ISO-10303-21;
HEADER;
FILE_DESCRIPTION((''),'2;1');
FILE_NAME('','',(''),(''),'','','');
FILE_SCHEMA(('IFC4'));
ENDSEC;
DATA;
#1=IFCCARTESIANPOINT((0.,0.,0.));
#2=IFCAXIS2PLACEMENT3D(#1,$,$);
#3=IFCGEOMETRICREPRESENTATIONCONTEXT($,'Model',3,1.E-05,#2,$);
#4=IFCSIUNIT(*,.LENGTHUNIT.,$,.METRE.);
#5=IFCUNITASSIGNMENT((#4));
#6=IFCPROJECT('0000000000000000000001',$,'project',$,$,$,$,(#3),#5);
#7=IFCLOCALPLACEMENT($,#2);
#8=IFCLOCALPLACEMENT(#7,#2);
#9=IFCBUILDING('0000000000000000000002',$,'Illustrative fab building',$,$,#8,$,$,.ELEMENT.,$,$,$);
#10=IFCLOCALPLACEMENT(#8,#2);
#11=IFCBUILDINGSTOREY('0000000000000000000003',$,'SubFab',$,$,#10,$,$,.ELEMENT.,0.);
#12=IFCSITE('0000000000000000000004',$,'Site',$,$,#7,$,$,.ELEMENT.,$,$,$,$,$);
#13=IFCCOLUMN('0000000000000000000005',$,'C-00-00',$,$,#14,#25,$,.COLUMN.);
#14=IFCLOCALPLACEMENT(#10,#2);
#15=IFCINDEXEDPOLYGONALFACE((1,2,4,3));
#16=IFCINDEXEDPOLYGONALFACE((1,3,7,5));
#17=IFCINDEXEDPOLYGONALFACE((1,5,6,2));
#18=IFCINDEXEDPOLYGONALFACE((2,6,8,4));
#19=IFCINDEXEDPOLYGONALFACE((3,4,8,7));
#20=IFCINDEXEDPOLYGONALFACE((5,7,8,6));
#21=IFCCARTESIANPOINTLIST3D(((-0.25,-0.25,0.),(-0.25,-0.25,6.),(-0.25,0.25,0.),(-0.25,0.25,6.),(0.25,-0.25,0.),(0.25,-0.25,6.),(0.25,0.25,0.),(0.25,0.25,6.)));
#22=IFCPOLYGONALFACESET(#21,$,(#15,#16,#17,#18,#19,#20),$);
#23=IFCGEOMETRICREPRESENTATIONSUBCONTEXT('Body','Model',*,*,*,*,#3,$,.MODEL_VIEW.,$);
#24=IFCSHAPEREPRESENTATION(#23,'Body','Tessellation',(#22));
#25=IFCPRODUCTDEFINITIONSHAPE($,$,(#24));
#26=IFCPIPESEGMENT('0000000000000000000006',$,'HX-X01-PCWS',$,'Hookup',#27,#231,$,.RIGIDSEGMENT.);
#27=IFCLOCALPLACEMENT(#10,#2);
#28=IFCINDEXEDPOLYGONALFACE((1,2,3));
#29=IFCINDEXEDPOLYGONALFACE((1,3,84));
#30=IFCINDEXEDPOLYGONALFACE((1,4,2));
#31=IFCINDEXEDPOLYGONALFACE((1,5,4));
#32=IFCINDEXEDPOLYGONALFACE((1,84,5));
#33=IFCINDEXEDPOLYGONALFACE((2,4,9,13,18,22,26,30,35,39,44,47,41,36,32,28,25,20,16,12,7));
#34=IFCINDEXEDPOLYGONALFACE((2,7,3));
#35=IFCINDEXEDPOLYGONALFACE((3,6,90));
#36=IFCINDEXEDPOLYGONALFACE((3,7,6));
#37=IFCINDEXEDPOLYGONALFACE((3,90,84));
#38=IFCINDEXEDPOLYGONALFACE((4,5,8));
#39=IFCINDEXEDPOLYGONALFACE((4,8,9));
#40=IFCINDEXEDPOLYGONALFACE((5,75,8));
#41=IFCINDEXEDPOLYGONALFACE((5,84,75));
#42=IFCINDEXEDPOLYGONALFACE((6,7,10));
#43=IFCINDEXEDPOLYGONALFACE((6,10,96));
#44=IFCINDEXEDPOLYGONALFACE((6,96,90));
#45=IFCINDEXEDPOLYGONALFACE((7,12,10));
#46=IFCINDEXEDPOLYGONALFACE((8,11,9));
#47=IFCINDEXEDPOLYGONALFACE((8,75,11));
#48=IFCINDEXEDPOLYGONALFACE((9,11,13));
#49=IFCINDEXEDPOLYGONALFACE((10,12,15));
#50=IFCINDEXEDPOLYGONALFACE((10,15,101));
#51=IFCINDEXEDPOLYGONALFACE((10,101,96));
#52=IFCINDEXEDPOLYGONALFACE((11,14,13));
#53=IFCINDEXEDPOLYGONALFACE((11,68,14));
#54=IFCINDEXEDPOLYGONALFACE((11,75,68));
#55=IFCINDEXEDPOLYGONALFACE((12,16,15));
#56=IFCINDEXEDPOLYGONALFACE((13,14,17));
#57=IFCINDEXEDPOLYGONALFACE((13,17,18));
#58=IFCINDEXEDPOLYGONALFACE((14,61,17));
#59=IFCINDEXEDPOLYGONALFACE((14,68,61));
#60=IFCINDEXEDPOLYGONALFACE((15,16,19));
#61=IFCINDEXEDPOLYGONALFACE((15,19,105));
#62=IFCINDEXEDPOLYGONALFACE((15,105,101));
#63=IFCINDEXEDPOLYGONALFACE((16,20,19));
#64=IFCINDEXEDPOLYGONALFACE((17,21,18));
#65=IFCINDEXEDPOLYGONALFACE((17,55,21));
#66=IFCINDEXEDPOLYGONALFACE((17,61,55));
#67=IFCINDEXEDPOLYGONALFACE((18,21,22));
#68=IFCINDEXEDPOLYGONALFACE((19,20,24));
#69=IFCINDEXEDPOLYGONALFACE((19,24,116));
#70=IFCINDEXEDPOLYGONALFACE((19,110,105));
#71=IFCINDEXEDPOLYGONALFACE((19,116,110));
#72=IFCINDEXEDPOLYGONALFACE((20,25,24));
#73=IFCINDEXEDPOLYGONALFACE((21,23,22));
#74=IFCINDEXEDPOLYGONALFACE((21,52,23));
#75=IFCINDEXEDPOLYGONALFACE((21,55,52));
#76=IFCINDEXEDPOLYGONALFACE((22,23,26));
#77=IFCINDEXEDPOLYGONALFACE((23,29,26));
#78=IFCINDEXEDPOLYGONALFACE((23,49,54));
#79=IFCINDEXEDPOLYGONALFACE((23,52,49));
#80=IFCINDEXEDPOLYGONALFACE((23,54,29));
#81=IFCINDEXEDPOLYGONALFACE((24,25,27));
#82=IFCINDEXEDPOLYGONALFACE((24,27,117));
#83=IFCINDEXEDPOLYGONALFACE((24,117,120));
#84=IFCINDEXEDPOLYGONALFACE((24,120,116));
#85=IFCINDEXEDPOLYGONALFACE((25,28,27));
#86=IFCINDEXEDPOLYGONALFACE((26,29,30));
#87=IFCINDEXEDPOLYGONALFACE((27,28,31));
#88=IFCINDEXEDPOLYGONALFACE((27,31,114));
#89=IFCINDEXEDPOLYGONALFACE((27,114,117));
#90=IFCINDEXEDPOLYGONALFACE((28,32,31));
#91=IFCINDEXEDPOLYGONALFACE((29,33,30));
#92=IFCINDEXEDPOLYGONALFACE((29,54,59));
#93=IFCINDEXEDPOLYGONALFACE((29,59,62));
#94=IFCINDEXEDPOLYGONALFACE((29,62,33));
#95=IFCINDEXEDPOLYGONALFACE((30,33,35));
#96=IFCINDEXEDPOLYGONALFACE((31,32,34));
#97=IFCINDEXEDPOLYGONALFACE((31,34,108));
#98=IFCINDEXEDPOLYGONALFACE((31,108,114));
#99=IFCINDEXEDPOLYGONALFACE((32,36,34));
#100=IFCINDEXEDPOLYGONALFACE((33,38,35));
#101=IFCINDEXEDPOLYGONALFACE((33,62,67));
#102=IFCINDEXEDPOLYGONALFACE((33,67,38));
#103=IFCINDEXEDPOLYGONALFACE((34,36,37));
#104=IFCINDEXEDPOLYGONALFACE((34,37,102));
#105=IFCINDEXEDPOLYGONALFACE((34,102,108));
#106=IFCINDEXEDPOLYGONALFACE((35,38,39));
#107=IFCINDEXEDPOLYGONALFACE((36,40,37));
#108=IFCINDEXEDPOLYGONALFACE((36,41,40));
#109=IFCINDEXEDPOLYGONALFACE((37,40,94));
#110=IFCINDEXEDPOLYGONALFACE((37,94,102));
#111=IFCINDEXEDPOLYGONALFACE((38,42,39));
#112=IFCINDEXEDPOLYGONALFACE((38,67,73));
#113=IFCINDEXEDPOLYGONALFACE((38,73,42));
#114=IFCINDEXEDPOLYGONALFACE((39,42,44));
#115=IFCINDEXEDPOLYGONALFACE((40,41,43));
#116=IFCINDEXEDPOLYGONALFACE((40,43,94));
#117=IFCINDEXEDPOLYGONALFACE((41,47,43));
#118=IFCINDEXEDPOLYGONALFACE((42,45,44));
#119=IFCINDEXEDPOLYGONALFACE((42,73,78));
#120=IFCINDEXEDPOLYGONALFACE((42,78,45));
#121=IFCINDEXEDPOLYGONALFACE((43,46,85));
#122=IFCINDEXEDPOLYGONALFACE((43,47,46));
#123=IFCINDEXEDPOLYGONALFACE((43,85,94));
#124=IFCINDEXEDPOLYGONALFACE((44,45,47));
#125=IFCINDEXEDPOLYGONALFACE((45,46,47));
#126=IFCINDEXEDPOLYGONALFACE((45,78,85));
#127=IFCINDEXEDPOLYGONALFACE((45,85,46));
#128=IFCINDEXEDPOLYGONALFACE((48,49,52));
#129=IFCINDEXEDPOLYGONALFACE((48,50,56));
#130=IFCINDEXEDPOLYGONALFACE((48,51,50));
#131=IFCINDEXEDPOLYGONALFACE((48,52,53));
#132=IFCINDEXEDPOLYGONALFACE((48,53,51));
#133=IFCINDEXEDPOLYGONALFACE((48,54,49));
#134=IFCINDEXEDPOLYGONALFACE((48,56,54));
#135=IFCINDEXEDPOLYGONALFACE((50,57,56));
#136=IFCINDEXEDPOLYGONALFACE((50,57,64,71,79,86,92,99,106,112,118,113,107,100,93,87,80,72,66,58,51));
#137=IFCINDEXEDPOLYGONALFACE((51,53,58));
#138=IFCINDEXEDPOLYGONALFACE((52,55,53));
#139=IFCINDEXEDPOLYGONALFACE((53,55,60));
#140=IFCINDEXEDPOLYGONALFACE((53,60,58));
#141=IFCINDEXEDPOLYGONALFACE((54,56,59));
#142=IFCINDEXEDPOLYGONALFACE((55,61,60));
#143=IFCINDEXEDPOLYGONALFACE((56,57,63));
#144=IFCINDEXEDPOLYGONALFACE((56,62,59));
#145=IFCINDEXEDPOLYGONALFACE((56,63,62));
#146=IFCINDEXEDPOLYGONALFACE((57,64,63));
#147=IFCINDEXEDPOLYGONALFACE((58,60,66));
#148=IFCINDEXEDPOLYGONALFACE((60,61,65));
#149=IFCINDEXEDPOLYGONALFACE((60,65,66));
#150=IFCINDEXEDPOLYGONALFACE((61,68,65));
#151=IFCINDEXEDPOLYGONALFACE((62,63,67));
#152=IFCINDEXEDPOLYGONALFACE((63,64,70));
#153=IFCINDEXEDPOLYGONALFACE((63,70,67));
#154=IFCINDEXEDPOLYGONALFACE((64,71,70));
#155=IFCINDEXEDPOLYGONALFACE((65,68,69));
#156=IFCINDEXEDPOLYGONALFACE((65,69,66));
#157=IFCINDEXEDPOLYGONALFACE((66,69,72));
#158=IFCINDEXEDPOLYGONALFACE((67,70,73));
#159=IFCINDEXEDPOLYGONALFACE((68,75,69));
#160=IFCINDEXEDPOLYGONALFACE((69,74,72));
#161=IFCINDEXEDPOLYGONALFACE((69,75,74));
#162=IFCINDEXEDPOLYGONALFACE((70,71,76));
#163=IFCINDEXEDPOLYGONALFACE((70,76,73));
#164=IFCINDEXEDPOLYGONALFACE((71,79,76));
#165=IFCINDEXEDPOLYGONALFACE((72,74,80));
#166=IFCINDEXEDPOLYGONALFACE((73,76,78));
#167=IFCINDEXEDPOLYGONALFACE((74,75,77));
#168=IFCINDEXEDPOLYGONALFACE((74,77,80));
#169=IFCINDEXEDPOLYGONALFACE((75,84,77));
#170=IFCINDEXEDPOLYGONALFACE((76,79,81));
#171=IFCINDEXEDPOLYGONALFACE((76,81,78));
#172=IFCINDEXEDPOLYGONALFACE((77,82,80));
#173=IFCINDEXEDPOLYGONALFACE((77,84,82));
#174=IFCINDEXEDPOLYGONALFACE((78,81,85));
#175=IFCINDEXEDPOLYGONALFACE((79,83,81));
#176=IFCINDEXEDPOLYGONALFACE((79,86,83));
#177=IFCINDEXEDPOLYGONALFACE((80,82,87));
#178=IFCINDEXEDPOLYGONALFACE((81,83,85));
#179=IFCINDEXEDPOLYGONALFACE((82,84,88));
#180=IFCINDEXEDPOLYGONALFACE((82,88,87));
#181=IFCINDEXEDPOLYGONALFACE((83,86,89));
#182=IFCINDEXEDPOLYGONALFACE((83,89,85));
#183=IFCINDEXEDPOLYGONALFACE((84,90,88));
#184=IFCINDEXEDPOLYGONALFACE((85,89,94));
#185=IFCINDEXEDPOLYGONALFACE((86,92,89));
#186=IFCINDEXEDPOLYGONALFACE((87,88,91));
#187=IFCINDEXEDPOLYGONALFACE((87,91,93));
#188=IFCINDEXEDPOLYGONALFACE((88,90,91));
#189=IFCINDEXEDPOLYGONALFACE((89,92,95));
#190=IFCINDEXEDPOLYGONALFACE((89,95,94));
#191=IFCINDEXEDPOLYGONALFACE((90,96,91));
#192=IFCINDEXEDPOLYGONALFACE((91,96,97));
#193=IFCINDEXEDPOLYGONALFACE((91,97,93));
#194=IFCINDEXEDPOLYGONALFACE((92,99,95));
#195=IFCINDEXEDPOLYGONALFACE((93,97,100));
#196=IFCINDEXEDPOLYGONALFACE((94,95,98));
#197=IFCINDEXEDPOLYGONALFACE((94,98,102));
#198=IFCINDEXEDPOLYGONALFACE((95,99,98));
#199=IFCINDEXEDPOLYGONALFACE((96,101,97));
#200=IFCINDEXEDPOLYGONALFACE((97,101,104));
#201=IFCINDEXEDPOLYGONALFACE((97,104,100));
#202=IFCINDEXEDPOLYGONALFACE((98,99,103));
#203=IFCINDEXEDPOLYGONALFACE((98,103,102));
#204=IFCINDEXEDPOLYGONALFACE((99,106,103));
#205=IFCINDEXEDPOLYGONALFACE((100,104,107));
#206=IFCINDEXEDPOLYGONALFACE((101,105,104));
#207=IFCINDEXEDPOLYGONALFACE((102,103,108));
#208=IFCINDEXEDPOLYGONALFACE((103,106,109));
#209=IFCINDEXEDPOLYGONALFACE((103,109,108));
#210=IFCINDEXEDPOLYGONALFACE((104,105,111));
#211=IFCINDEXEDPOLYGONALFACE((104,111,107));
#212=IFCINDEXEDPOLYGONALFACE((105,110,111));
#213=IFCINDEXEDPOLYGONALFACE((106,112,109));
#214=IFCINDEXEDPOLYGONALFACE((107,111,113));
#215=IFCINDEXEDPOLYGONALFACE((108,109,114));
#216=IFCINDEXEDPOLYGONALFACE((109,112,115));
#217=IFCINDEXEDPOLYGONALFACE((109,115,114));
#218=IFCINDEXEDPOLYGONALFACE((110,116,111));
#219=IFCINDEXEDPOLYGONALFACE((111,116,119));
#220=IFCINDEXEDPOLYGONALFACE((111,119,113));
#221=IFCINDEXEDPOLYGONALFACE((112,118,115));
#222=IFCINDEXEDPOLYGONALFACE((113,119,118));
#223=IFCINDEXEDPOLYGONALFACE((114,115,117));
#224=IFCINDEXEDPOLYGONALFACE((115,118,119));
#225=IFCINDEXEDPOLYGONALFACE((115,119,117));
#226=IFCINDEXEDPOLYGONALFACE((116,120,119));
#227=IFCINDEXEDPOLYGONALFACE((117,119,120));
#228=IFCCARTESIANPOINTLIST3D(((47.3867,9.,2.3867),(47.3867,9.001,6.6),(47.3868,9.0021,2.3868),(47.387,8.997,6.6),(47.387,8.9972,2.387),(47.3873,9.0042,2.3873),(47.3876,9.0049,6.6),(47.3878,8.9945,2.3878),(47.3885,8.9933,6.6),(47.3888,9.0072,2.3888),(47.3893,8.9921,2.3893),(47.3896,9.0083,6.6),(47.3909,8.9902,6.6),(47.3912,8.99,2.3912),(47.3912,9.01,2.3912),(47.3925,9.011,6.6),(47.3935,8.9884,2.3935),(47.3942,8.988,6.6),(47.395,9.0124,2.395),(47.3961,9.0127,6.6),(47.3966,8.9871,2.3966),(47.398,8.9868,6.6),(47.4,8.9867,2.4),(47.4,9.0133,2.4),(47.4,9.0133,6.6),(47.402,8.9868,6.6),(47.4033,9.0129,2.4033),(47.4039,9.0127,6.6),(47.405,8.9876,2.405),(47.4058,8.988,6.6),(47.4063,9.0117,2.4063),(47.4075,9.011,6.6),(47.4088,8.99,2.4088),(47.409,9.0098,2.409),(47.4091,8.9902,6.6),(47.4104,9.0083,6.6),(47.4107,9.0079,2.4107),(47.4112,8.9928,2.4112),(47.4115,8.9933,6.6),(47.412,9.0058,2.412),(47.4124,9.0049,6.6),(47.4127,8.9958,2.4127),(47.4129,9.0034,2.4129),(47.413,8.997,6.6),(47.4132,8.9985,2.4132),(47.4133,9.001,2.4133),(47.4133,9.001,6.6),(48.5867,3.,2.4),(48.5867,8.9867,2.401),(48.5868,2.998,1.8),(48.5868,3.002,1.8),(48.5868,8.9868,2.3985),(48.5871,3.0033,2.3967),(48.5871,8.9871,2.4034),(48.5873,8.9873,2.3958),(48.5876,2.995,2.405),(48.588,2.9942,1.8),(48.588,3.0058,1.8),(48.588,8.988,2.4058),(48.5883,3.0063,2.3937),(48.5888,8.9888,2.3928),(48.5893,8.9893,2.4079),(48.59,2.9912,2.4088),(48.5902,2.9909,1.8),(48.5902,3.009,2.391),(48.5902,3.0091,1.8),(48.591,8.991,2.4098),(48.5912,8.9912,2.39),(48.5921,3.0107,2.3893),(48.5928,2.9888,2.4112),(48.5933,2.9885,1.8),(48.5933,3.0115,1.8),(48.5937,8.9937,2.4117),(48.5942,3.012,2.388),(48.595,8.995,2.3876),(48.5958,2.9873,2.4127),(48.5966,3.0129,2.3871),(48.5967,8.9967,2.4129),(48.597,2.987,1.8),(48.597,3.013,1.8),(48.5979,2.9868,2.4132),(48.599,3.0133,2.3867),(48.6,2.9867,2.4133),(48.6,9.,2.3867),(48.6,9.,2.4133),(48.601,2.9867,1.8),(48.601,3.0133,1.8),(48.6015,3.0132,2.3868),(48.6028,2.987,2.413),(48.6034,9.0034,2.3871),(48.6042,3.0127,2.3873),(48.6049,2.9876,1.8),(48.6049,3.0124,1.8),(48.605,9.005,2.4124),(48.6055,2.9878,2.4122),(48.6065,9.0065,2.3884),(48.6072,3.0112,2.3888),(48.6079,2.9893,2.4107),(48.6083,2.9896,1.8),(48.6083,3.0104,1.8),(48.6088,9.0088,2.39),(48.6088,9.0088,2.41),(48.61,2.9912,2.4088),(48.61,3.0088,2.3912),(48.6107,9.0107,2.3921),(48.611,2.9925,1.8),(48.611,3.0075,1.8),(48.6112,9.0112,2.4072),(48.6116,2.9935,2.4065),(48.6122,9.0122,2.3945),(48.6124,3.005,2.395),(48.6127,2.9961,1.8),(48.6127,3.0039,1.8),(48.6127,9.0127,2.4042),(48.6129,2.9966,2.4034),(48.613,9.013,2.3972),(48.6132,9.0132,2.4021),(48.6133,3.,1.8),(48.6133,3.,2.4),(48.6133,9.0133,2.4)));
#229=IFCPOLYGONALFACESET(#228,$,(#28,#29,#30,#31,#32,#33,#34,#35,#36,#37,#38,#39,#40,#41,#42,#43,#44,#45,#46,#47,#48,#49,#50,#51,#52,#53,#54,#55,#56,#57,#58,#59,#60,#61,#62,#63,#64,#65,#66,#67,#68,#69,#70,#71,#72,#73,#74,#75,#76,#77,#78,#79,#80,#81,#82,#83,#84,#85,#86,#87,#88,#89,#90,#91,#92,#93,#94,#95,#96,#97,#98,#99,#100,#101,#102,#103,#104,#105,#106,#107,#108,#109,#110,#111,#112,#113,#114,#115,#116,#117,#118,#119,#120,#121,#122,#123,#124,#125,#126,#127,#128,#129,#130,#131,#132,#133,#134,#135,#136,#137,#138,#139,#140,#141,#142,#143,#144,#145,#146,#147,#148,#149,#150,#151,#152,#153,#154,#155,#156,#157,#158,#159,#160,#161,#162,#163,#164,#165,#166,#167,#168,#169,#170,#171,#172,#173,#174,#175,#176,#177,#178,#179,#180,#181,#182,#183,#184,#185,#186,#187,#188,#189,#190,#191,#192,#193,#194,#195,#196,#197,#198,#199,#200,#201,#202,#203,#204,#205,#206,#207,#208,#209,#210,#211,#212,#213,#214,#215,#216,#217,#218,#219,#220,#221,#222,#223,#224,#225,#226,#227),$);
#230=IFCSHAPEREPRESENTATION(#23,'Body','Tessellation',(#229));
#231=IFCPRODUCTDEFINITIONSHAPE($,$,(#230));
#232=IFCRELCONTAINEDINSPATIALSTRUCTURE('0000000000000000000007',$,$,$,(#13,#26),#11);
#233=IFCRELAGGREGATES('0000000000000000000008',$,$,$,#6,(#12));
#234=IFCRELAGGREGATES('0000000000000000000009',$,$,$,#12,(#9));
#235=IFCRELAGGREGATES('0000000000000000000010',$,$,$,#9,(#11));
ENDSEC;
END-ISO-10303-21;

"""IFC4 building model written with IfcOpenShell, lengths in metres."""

from ifc_helpers import new_model, entity, si_unit, origin, origin_2d, place, context, subcontext, project, spatial, rectangle, extrude, element, save


model = new_model("IFC4")

# Units and contexts
model_context = context("Model", 3, precision=1e-05, world=origin())
body_context = subcontext(model_context, "Body", "Model", "MODEL_VIEW")
ifc_project = project(units=[si_unit("LENGTHUNIT", "METRE")], contexts=[model_context])

# Site, building, storey
site_placement = place(None, origin())
site = spatial("IfcSite", under=ifc_project, at=site_placement, Name="Site", CompositionType="ELEMENT")
building_placement = place(site_placement, origin())
building = spatial("IfcBuilding", under=site, at=building_placement, Name="Illustrative fab building", CompositionType="ELEMENT")
storey_placement = place(building_placement, origin())
storey = spatial("IfcBuildingStorey", under=building, at=storey_placement, Name="SubFab", CompositionType="ELEMENT", Elevation=0.0)

# Column
column_placement = place(storey_placement, origin())
element("IfcColumn", 1, at=column_placement, inside=storey, Name="C-00-00", PredefinedType="COLUMN", context=body_context, shape_type="SweptSolid", body=[
    extrude(rectangle(XDim=0.5, YDim=0.5, at=origin_2d()), origin(), (0.0, 0.0, 1.0), 6.0),
])

# Pipe segment
pipe_segment_1_placement = place(storey_placement, origin())
element("IfcPipeSegment", 2, at=pipe_segment_1_placement, inside=storey, Name="HX-X01-PCWS", ObjectType="Hookup", PredefinedType="RIGIDSEGMENT", context=body_context, shape_type="AdvancedSweptSolid", body=[
    entity("IfcSweptDiskSolid", entity("IfcPolyline", [entity("IfcCartesianPoint", [48.6, 3.0, 1.8]), entity("IfcCartesianPoint", [48.6, 3.0, 2.4]), entity("IfcCartesianPoint", [48.6, 9.0, 2.4]), entity("IfcCartesianPoint", [47.4, 9.0, 2.4]), entity("IfcCartesianPoint", [47.4, 9.0, 6.6])]), 0.0133),
])

save(model, "model.ifc")
